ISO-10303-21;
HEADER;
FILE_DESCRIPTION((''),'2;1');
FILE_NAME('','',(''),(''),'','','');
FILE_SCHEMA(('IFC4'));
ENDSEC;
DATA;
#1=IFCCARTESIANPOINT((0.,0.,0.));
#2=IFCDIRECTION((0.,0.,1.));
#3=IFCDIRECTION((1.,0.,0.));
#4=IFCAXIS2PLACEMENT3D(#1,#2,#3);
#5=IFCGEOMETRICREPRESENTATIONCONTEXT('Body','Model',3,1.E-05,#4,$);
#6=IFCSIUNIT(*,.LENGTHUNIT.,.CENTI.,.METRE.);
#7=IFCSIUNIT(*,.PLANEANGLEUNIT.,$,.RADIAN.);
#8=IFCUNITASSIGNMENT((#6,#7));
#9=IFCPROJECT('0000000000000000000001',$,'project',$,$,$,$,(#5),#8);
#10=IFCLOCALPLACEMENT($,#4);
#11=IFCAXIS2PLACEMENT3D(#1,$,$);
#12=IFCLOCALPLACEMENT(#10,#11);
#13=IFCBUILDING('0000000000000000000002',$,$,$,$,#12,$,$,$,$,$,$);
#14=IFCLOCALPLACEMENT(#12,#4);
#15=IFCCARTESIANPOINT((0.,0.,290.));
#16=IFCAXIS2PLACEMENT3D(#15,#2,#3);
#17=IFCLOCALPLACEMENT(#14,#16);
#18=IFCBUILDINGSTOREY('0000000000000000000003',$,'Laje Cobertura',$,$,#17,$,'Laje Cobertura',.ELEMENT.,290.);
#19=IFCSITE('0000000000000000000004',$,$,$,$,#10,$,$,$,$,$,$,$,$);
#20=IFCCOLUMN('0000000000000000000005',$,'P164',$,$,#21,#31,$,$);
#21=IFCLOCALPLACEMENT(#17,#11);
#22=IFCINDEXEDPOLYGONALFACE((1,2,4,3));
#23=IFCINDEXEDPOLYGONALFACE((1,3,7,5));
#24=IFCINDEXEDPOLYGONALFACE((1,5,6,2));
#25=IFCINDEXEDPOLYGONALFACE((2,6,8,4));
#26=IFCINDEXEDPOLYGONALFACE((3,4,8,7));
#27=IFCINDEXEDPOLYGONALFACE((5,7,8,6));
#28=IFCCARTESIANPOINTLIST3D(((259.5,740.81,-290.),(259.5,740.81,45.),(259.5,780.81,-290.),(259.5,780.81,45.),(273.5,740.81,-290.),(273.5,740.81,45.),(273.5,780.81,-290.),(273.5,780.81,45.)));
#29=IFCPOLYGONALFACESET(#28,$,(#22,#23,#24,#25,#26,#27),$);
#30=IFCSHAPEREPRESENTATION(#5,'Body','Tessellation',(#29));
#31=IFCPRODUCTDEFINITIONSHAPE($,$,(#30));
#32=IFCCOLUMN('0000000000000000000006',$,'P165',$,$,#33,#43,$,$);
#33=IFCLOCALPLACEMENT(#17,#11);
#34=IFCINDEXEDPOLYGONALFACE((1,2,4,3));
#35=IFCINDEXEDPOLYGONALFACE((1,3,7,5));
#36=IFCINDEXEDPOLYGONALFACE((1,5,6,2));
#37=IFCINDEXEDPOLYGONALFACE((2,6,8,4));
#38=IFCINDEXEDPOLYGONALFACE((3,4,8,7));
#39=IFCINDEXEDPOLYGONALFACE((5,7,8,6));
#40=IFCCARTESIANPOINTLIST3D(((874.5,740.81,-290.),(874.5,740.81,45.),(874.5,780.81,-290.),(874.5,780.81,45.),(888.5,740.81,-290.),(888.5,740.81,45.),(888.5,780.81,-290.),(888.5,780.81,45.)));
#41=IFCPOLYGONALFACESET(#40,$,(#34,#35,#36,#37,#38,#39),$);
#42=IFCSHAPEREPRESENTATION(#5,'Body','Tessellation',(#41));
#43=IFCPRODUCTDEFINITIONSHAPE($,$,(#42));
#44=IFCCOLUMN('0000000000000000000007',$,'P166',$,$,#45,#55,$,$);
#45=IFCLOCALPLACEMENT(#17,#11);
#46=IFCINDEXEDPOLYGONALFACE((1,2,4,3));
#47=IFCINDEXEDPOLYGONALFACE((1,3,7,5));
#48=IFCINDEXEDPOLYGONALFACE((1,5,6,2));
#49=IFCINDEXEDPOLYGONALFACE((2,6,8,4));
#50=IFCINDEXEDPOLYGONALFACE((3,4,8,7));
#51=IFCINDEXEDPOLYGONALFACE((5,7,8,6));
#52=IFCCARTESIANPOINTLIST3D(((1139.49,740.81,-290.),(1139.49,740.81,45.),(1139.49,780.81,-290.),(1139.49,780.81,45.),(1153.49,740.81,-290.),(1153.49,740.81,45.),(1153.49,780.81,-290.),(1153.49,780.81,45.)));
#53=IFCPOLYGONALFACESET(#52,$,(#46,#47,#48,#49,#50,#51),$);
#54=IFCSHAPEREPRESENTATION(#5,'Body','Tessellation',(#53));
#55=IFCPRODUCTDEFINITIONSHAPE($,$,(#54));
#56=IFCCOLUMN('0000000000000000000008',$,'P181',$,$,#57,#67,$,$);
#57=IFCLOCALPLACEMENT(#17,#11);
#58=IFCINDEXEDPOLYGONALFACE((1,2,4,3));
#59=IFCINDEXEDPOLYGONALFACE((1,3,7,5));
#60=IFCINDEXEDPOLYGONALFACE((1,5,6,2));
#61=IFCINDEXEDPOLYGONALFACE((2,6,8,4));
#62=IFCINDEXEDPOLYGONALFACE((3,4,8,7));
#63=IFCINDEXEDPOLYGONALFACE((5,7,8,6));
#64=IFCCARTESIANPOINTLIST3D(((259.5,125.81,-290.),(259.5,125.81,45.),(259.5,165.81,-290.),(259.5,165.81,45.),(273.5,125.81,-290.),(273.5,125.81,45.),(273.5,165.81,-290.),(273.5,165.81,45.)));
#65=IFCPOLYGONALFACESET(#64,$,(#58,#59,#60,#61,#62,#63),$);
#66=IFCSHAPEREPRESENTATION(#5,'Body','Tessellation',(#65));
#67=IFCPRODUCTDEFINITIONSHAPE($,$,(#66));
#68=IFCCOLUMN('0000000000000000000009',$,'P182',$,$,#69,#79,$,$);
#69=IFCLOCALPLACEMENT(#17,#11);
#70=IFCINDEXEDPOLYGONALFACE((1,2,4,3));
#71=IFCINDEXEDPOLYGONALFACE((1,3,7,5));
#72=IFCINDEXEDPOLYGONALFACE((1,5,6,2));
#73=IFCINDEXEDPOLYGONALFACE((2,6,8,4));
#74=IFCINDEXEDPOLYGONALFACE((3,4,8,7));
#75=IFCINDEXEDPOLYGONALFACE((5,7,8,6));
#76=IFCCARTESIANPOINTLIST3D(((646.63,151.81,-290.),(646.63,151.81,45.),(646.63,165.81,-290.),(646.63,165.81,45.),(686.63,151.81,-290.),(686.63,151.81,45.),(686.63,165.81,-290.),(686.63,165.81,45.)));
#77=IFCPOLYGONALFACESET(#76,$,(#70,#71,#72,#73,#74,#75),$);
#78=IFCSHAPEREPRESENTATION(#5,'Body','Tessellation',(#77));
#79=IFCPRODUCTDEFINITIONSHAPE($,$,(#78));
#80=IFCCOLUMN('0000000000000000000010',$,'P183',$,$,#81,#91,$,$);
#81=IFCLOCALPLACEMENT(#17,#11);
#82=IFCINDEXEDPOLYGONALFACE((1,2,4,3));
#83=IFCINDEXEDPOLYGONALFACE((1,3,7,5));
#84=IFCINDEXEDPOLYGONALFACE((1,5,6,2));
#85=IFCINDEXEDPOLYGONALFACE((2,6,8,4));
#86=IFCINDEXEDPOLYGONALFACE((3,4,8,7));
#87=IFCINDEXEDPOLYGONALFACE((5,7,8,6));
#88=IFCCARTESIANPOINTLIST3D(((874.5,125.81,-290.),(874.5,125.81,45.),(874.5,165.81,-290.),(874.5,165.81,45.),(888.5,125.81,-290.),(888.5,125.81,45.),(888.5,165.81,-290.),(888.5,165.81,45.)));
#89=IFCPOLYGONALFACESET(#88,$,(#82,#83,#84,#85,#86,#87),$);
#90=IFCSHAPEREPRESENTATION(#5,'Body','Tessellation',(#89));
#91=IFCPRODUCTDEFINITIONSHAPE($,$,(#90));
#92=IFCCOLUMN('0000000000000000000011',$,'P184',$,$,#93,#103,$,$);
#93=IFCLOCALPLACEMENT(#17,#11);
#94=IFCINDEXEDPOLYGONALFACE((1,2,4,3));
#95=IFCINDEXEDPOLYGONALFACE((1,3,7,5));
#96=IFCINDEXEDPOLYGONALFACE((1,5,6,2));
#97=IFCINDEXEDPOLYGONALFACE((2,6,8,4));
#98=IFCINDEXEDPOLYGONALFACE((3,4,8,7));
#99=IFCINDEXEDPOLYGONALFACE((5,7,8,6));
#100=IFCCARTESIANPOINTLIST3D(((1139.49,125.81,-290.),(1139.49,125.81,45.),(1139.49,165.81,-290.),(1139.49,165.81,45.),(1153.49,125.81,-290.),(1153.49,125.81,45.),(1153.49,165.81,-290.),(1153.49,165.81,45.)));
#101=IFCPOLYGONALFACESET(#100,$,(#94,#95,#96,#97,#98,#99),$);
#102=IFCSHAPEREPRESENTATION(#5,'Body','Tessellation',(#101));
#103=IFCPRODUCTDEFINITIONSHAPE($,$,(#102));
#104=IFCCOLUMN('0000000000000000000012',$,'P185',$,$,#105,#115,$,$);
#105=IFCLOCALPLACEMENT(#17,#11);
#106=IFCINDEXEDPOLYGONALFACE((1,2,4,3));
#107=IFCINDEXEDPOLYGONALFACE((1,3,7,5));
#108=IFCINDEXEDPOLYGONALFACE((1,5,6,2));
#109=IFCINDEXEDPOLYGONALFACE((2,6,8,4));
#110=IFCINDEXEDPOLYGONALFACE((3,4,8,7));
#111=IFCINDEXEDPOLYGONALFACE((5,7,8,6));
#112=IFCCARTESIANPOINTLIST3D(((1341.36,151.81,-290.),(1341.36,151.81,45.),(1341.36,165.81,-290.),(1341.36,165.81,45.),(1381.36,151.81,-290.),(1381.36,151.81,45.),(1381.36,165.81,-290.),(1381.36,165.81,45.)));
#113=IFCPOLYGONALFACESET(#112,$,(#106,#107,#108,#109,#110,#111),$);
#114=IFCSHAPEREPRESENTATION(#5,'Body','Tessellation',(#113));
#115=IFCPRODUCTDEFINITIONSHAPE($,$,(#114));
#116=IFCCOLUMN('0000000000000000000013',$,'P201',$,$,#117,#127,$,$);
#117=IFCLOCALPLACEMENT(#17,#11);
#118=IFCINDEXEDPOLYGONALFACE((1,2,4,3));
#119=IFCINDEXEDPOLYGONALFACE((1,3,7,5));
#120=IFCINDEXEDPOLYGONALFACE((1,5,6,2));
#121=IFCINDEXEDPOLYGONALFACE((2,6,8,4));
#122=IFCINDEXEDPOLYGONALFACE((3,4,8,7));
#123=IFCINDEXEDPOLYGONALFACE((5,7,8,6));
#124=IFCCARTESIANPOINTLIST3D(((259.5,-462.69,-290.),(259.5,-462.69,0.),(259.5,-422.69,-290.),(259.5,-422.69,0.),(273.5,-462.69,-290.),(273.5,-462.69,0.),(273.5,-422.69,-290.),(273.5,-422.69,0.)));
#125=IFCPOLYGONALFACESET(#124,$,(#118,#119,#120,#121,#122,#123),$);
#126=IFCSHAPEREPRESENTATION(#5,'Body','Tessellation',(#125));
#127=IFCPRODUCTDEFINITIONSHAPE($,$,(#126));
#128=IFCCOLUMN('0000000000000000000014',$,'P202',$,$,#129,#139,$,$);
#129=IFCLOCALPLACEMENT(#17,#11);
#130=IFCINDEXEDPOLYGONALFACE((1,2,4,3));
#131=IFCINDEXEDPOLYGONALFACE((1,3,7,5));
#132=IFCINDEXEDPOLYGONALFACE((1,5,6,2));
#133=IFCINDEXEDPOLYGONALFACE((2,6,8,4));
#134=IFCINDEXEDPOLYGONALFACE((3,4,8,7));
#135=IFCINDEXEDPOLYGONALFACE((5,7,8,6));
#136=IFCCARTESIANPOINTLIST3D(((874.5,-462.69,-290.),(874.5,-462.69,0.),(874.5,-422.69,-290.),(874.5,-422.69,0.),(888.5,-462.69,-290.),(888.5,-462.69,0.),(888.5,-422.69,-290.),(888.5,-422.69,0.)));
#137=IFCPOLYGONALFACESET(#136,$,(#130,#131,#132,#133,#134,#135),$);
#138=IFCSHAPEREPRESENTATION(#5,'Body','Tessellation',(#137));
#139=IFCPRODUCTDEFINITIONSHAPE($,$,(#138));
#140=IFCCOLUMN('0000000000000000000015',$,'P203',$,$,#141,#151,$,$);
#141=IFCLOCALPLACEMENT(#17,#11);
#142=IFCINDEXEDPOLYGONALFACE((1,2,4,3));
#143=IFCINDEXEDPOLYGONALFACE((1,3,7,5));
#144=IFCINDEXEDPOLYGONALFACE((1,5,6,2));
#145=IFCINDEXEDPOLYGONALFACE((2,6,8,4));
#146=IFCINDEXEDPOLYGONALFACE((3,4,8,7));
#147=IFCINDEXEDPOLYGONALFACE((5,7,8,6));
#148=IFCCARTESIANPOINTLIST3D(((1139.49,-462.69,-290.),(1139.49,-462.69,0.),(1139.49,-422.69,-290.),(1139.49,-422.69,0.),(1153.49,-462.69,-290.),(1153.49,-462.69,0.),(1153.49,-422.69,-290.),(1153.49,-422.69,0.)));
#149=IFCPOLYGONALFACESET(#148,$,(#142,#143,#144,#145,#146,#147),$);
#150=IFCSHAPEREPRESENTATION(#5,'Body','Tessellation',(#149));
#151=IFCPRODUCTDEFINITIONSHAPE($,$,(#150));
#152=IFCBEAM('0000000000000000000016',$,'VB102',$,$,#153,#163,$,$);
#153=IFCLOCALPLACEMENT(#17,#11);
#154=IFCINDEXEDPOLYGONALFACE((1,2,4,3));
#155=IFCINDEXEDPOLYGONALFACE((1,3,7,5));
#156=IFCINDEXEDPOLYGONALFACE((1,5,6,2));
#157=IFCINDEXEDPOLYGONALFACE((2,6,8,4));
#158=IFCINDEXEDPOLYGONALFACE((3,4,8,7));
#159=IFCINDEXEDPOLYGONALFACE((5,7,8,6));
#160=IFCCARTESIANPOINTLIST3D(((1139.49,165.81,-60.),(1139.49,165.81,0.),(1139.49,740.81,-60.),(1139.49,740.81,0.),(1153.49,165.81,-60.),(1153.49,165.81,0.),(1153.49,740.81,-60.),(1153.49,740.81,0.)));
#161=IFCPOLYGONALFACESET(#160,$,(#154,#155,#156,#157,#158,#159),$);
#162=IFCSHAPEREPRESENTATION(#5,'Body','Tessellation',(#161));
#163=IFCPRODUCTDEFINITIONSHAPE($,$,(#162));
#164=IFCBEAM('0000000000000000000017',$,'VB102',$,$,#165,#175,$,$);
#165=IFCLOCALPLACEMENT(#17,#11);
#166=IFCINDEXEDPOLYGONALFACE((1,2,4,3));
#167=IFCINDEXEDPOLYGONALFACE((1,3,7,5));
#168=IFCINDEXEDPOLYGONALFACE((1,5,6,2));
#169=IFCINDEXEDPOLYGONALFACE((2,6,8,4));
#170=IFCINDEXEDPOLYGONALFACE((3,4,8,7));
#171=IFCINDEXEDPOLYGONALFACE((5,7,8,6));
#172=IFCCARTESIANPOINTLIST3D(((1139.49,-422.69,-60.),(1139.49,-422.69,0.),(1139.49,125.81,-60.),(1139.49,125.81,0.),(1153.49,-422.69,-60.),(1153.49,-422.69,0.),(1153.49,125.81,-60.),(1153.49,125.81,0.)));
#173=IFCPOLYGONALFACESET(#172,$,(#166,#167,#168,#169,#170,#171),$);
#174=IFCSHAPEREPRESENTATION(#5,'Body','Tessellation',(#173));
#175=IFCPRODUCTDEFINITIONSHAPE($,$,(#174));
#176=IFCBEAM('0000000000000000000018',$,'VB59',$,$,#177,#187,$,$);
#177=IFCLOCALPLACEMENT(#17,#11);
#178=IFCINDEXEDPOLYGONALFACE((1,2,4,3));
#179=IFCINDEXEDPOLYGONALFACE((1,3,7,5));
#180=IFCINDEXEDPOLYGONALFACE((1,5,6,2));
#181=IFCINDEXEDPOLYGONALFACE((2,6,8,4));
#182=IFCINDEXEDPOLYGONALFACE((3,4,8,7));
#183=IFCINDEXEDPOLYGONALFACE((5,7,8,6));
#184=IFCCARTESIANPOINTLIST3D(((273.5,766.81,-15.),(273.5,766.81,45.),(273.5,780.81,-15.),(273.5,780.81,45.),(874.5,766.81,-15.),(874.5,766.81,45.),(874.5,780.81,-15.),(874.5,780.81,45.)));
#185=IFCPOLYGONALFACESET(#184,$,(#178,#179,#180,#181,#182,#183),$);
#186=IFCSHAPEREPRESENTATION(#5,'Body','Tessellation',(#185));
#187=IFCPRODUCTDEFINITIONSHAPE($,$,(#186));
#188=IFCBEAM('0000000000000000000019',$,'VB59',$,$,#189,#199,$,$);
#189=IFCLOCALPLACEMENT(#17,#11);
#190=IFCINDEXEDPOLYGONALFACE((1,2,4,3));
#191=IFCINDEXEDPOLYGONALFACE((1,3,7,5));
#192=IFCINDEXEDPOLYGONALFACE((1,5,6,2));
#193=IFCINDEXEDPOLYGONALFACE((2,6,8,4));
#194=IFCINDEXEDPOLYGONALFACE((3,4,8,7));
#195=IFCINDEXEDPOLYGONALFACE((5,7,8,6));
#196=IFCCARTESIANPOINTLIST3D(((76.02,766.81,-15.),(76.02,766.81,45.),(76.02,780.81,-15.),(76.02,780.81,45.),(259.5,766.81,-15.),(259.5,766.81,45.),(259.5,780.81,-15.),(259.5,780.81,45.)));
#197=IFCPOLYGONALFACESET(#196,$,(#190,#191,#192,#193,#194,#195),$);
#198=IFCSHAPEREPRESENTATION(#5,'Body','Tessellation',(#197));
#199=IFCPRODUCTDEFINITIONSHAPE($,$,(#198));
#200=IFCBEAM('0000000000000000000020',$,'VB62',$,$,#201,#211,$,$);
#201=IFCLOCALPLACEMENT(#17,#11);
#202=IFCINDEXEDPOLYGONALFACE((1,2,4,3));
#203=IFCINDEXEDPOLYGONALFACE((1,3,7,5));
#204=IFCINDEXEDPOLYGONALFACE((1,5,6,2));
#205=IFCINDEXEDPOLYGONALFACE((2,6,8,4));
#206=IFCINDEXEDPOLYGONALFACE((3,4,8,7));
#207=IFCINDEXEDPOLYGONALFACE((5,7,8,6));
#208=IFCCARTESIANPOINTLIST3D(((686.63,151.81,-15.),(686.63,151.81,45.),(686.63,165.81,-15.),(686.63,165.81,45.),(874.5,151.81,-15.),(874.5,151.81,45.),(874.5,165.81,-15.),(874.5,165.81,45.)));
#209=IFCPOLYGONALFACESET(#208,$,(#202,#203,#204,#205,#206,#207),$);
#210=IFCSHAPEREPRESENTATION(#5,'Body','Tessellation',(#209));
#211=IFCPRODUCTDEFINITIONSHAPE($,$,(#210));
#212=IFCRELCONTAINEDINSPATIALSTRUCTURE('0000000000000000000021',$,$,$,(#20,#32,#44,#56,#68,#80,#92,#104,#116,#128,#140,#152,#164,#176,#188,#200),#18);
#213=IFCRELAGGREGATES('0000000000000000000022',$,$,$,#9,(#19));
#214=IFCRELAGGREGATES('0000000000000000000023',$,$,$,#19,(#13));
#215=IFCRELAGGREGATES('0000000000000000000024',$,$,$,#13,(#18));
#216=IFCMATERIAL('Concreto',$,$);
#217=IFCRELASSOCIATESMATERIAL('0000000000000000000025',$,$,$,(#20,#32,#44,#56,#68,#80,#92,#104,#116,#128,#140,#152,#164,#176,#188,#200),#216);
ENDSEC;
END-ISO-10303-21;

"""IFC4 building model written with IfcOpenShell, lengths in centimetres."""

from ifc_helpers import new_model, si_unit, frame, origin, origin_with_axes, origin_2d_with_axis, place, context, project, spatial, rectangle, extrude, material, element, save


model = new_model("IFC4")

# Units and contexts
model_context = context("Model", 3, precision=1e-05, world=origin_with_axes(), identifier="Body")
ifc_project = project(units=[si_unit("LENGTHUNIT", "METRE", prefix="CENTI"), si_unit("PLANEANGLEUNIT", "RADIAN")], contexts=[model_context])

# Site, building, storey
site_placement = place(None, origin_with_axes())
site = spatial("IfcSite", under=ifc_project, at=site_placement)
building_placement = place(site_placement, origin())
building = spatial("IfcBuilding", under=site, at=building_placement)
placement = place(building_placement, origin_with_axes())
storey_placement = place(placement, frame((0.0, 0.0, 290.0), z_axis=(0.0, 0.0, 1.0), x_axis=(1.0, 0.0, 0.0)))
storey = spatial("IfcBuildingStorey", under=building, at=storey_placement, Name="Laje Cobertura", LongName="Laje Cobertura", CompositionType="ELEMENT", Elevation=290.0)

# Columns
ifc_material = material(Name="Concreto")
for number, where, z_axis, x_axis, name in (
    (1, (266.5, 760.81, 45.0), (0.0, 0.0, 1.0), (1.0, 0.0, 0.0), "P164"),
    (2, (881.5, 760.81, 45.0), (0.0, 0.0, 1.0), (1.0, 0.0, 0.0), "P165"),
    (3, (1146.49, 760.81, 45.0), (0.0, 0.0, 1.0), (1.0, 0.0, 0.0), "P166"),
    (4, (266.5, 145.81, 45.0), (0.0, 0.0, 1.0), (1.0, 0.0, 0.0), "P181"),
):
    element("IfcColumn", number, at=place(storey_placement, frame(where, z_axis=z_axis, x_axis=x_axis)), inside=storey, material=ifc_material, Name=name, context=model_context, shape_type="SolidModel", body=[
        extrude(rectangle(XDim=14.0, YDim=40.0, at=origin_2d_with_axis()), origin_with_axes(), (0.0, 0.0, -1.0), 335.0),
    ])
column_1_placement = place(storey_placement, frame((666.63, 158.81, 45.0), z_axis=(0.0, 0.0, 1.0), x_axis=(1.0, 0.0, 0.0)))
element("IfcColumn", 5, at=column_1_placement, inside=storey, material=ifc_material, Name="P182", context=model_context, shape_type="SolidModel", body=[
    extrude(rectangle(XDim=14.0, YDim=40.0, at=origin_2d_with_axis()), frame((0.0, 0.0, 0.0), z_axis=(0.0, 0.0, 1.0), x_axis=(0.0, -1.0, 0.0)), (0.0, 0.0, -1.0), 335.0),
])
for number, where, z_axis, x_axis, name in (
    (6, (881.5, 145.81, 45.0), (0.0, 0.0, 1.0), (1.0, 0.0, 0.0), "P183"),
    (7, (1146.49, 145.81, 45.0), (0.0, 0.0, 1.0), (1.0, 0.0, 0.0), "P184"),
):
    element("IfcColumn", number, at=place(storey_placement, frame(where, z_axis=z_axis, x_axis=x_axis)), inside=storey, material=ifc_material, Name=name, context=model_context, shape_type="SolidModel", body=[
        extrude(rectangle(XDim=14.0, YDim=40.0, at=origin_2d_with_axis()), origin_with_axes(), (0.0, 0.0, -1.0), 335.0),
    ])
column_2_placement = place(storey_placement, frame((1361.36, 158.81, 45.0), z_axis=(0.0, 0.0, 1.0), x_axis=(1.0, 0.0, 0.0)))
element("IfcColumn", 8, at=column_2_placement, inside=storey, material=ifc_material, Name="P185", context=model_context, shape_type="SolidModel", body=[
    extrude(rectangle(XDim=14.0, YDim=40.0, at=origin_2d_with_axis()), frame((0.0, 0.0, 0.0), z_axis=(0.0, 0.0, 1.0), x_axis=(0.0, 1.0, 0.0)), (0.0, 0.0, -1.0), 335.0),
])
for number, where, z_axis, x_axis, name in (
    (9, (266.5, -442.69, 0.0), (0.0, 0.0, 1.0), (1.0, 0.0, 0.0), "P201"),
    (10, (881.5, -442.69, 0.0), (0.0, 0.0, 1.0), (1.0, 0.0, 0.0), "P202"),
    (11, (1146.49, -442.69, 0.0), (0.0, 0.0, 1.0), (1.0, 0.0, 0.0), "P203"),
):
    element("IfcColumn", number, at=place(storey_placement, frame(where, z_axis=z_axis, x_axis=x_axis)), inside=storey, material=ifc_material, Name=name, context=model_context, shape_type="SolidModel", body=[
        extrude(rectangle(XDim=14.0, YDim=40.0, at=origin_2d_with_axis()), origin_with_axes(), (0.0, 0.0, -1.0), 290.0),
    ])

# Beams
beam_1_placement = place(storey_placement, frame((1146.49, 453.31, 0.0), z_axis=(0.0, 0.0, 1.0), x_axis=(1.0, 0.0, 0.0)))
element("IfcBeam", 12, at=beam_1_placement, inside=storey, material=ifc_material, Name="VB102", context=model_context, shape_type="SolidModel", body=[
    extrude(rectangle(XDim=14.0, YDim=60.0, at=origin_2d_with_axis()), frame((0.0, -287.5, -30.0), z_axis=(0.0, 1.0, 0.0), x_axis=(1.0, 0.0, 0.0)), (0.0, 0.0, 1.0), 575.0),
])
beam_2_placement = place(storey_placement, frame((1146.49, -148.44, 0.0), z_axis=(0.0, 0.0, 1.0), x_axis=(1.0, 0.0, 0.0)))
element("IfcBeam", 13, at=beam_2_placement, inside=storey, material=ifc_material, Name="VB102", context=model_context, shape_type="SolidModel", body=[
    extrude(rectangle(XDim=14.0, YDim=60.0, at=origin_2d_with_axis()), frame((0.0, -274.25, -30.0), z_axis=(0.0, 1.0, 0.0), x_axis=(1.0, 0.0, 0.0)), (0.0, 0.0, 1.0), 548.5),
])
beam_3_placement = place(storey_placement, frame((574.0, 773.81, 45.0), z_axis=(0.0, 0.0, 1.0), x_axis=(1.0, 0.0, 0.0)))
element("IfcBeam", 14, at=beam_3_placement, inside=storey, material=ifc_material, Name="VB59", context=model_context, shape_type="SolidModel", body=[
    extrude(rectangle(XDim=14.0, YDim=60.0, at=origin_2d_with_axis()), frame((-300.5, 0.0, -30.0), z_axis=(1.0, 0.0, 0.0), x_axis=(0.0, 1.0, 0.0)), (0.0, 0.0, 1.0), 601.0),
])
beam_4_placement = place(storey_placement, frame((167.76, 773.81, 45.0), z_axis=(0.0, 0.0, 1.0), x_axis=(1.0, 0.0, 0.0)))
element("IfcBeam", 15, at=beam_4_placement, inside=storey, material=ifc_material, Name="VB59", context=model_context, shape_type="SolidModel", body=[
    extrude(rectangle(XDim=14.0, YDim=60.0, at=origin_2d_with_axis()), frame((-91.74, 0.0, -30.0), z_axis=(1.0, 0.0, 0.0), x_axis=(0.0, 1.0, 0.0)), (0.0, 0.0, 1.0), 183.48),
])
beam_5_placement = place(storey_placement, frame((780.57, 158.81, 45.0), z_axis=(0.0, 0.0, 1.0), x_axis=(1.0, 0.0, 0.0)))
element("IfcBeam", 16, at=beam_5_placement, inside=storey, material=ifc_material, Name="VB62", context=model_context, shape_type="SolidModel", body=[
    extrude(rectangle(XDim=14.0, YDim=60.0, at=origin_2d_with_axis()), frame((-93.94, 0.0, -30.0), z_axis=(1.0, 0.0, 0.0), x_axis=(0.0, 1.0, 0.0)), (0.0, 0.0, 1.0), 187.87),
])

save(model, "model.ifc")
